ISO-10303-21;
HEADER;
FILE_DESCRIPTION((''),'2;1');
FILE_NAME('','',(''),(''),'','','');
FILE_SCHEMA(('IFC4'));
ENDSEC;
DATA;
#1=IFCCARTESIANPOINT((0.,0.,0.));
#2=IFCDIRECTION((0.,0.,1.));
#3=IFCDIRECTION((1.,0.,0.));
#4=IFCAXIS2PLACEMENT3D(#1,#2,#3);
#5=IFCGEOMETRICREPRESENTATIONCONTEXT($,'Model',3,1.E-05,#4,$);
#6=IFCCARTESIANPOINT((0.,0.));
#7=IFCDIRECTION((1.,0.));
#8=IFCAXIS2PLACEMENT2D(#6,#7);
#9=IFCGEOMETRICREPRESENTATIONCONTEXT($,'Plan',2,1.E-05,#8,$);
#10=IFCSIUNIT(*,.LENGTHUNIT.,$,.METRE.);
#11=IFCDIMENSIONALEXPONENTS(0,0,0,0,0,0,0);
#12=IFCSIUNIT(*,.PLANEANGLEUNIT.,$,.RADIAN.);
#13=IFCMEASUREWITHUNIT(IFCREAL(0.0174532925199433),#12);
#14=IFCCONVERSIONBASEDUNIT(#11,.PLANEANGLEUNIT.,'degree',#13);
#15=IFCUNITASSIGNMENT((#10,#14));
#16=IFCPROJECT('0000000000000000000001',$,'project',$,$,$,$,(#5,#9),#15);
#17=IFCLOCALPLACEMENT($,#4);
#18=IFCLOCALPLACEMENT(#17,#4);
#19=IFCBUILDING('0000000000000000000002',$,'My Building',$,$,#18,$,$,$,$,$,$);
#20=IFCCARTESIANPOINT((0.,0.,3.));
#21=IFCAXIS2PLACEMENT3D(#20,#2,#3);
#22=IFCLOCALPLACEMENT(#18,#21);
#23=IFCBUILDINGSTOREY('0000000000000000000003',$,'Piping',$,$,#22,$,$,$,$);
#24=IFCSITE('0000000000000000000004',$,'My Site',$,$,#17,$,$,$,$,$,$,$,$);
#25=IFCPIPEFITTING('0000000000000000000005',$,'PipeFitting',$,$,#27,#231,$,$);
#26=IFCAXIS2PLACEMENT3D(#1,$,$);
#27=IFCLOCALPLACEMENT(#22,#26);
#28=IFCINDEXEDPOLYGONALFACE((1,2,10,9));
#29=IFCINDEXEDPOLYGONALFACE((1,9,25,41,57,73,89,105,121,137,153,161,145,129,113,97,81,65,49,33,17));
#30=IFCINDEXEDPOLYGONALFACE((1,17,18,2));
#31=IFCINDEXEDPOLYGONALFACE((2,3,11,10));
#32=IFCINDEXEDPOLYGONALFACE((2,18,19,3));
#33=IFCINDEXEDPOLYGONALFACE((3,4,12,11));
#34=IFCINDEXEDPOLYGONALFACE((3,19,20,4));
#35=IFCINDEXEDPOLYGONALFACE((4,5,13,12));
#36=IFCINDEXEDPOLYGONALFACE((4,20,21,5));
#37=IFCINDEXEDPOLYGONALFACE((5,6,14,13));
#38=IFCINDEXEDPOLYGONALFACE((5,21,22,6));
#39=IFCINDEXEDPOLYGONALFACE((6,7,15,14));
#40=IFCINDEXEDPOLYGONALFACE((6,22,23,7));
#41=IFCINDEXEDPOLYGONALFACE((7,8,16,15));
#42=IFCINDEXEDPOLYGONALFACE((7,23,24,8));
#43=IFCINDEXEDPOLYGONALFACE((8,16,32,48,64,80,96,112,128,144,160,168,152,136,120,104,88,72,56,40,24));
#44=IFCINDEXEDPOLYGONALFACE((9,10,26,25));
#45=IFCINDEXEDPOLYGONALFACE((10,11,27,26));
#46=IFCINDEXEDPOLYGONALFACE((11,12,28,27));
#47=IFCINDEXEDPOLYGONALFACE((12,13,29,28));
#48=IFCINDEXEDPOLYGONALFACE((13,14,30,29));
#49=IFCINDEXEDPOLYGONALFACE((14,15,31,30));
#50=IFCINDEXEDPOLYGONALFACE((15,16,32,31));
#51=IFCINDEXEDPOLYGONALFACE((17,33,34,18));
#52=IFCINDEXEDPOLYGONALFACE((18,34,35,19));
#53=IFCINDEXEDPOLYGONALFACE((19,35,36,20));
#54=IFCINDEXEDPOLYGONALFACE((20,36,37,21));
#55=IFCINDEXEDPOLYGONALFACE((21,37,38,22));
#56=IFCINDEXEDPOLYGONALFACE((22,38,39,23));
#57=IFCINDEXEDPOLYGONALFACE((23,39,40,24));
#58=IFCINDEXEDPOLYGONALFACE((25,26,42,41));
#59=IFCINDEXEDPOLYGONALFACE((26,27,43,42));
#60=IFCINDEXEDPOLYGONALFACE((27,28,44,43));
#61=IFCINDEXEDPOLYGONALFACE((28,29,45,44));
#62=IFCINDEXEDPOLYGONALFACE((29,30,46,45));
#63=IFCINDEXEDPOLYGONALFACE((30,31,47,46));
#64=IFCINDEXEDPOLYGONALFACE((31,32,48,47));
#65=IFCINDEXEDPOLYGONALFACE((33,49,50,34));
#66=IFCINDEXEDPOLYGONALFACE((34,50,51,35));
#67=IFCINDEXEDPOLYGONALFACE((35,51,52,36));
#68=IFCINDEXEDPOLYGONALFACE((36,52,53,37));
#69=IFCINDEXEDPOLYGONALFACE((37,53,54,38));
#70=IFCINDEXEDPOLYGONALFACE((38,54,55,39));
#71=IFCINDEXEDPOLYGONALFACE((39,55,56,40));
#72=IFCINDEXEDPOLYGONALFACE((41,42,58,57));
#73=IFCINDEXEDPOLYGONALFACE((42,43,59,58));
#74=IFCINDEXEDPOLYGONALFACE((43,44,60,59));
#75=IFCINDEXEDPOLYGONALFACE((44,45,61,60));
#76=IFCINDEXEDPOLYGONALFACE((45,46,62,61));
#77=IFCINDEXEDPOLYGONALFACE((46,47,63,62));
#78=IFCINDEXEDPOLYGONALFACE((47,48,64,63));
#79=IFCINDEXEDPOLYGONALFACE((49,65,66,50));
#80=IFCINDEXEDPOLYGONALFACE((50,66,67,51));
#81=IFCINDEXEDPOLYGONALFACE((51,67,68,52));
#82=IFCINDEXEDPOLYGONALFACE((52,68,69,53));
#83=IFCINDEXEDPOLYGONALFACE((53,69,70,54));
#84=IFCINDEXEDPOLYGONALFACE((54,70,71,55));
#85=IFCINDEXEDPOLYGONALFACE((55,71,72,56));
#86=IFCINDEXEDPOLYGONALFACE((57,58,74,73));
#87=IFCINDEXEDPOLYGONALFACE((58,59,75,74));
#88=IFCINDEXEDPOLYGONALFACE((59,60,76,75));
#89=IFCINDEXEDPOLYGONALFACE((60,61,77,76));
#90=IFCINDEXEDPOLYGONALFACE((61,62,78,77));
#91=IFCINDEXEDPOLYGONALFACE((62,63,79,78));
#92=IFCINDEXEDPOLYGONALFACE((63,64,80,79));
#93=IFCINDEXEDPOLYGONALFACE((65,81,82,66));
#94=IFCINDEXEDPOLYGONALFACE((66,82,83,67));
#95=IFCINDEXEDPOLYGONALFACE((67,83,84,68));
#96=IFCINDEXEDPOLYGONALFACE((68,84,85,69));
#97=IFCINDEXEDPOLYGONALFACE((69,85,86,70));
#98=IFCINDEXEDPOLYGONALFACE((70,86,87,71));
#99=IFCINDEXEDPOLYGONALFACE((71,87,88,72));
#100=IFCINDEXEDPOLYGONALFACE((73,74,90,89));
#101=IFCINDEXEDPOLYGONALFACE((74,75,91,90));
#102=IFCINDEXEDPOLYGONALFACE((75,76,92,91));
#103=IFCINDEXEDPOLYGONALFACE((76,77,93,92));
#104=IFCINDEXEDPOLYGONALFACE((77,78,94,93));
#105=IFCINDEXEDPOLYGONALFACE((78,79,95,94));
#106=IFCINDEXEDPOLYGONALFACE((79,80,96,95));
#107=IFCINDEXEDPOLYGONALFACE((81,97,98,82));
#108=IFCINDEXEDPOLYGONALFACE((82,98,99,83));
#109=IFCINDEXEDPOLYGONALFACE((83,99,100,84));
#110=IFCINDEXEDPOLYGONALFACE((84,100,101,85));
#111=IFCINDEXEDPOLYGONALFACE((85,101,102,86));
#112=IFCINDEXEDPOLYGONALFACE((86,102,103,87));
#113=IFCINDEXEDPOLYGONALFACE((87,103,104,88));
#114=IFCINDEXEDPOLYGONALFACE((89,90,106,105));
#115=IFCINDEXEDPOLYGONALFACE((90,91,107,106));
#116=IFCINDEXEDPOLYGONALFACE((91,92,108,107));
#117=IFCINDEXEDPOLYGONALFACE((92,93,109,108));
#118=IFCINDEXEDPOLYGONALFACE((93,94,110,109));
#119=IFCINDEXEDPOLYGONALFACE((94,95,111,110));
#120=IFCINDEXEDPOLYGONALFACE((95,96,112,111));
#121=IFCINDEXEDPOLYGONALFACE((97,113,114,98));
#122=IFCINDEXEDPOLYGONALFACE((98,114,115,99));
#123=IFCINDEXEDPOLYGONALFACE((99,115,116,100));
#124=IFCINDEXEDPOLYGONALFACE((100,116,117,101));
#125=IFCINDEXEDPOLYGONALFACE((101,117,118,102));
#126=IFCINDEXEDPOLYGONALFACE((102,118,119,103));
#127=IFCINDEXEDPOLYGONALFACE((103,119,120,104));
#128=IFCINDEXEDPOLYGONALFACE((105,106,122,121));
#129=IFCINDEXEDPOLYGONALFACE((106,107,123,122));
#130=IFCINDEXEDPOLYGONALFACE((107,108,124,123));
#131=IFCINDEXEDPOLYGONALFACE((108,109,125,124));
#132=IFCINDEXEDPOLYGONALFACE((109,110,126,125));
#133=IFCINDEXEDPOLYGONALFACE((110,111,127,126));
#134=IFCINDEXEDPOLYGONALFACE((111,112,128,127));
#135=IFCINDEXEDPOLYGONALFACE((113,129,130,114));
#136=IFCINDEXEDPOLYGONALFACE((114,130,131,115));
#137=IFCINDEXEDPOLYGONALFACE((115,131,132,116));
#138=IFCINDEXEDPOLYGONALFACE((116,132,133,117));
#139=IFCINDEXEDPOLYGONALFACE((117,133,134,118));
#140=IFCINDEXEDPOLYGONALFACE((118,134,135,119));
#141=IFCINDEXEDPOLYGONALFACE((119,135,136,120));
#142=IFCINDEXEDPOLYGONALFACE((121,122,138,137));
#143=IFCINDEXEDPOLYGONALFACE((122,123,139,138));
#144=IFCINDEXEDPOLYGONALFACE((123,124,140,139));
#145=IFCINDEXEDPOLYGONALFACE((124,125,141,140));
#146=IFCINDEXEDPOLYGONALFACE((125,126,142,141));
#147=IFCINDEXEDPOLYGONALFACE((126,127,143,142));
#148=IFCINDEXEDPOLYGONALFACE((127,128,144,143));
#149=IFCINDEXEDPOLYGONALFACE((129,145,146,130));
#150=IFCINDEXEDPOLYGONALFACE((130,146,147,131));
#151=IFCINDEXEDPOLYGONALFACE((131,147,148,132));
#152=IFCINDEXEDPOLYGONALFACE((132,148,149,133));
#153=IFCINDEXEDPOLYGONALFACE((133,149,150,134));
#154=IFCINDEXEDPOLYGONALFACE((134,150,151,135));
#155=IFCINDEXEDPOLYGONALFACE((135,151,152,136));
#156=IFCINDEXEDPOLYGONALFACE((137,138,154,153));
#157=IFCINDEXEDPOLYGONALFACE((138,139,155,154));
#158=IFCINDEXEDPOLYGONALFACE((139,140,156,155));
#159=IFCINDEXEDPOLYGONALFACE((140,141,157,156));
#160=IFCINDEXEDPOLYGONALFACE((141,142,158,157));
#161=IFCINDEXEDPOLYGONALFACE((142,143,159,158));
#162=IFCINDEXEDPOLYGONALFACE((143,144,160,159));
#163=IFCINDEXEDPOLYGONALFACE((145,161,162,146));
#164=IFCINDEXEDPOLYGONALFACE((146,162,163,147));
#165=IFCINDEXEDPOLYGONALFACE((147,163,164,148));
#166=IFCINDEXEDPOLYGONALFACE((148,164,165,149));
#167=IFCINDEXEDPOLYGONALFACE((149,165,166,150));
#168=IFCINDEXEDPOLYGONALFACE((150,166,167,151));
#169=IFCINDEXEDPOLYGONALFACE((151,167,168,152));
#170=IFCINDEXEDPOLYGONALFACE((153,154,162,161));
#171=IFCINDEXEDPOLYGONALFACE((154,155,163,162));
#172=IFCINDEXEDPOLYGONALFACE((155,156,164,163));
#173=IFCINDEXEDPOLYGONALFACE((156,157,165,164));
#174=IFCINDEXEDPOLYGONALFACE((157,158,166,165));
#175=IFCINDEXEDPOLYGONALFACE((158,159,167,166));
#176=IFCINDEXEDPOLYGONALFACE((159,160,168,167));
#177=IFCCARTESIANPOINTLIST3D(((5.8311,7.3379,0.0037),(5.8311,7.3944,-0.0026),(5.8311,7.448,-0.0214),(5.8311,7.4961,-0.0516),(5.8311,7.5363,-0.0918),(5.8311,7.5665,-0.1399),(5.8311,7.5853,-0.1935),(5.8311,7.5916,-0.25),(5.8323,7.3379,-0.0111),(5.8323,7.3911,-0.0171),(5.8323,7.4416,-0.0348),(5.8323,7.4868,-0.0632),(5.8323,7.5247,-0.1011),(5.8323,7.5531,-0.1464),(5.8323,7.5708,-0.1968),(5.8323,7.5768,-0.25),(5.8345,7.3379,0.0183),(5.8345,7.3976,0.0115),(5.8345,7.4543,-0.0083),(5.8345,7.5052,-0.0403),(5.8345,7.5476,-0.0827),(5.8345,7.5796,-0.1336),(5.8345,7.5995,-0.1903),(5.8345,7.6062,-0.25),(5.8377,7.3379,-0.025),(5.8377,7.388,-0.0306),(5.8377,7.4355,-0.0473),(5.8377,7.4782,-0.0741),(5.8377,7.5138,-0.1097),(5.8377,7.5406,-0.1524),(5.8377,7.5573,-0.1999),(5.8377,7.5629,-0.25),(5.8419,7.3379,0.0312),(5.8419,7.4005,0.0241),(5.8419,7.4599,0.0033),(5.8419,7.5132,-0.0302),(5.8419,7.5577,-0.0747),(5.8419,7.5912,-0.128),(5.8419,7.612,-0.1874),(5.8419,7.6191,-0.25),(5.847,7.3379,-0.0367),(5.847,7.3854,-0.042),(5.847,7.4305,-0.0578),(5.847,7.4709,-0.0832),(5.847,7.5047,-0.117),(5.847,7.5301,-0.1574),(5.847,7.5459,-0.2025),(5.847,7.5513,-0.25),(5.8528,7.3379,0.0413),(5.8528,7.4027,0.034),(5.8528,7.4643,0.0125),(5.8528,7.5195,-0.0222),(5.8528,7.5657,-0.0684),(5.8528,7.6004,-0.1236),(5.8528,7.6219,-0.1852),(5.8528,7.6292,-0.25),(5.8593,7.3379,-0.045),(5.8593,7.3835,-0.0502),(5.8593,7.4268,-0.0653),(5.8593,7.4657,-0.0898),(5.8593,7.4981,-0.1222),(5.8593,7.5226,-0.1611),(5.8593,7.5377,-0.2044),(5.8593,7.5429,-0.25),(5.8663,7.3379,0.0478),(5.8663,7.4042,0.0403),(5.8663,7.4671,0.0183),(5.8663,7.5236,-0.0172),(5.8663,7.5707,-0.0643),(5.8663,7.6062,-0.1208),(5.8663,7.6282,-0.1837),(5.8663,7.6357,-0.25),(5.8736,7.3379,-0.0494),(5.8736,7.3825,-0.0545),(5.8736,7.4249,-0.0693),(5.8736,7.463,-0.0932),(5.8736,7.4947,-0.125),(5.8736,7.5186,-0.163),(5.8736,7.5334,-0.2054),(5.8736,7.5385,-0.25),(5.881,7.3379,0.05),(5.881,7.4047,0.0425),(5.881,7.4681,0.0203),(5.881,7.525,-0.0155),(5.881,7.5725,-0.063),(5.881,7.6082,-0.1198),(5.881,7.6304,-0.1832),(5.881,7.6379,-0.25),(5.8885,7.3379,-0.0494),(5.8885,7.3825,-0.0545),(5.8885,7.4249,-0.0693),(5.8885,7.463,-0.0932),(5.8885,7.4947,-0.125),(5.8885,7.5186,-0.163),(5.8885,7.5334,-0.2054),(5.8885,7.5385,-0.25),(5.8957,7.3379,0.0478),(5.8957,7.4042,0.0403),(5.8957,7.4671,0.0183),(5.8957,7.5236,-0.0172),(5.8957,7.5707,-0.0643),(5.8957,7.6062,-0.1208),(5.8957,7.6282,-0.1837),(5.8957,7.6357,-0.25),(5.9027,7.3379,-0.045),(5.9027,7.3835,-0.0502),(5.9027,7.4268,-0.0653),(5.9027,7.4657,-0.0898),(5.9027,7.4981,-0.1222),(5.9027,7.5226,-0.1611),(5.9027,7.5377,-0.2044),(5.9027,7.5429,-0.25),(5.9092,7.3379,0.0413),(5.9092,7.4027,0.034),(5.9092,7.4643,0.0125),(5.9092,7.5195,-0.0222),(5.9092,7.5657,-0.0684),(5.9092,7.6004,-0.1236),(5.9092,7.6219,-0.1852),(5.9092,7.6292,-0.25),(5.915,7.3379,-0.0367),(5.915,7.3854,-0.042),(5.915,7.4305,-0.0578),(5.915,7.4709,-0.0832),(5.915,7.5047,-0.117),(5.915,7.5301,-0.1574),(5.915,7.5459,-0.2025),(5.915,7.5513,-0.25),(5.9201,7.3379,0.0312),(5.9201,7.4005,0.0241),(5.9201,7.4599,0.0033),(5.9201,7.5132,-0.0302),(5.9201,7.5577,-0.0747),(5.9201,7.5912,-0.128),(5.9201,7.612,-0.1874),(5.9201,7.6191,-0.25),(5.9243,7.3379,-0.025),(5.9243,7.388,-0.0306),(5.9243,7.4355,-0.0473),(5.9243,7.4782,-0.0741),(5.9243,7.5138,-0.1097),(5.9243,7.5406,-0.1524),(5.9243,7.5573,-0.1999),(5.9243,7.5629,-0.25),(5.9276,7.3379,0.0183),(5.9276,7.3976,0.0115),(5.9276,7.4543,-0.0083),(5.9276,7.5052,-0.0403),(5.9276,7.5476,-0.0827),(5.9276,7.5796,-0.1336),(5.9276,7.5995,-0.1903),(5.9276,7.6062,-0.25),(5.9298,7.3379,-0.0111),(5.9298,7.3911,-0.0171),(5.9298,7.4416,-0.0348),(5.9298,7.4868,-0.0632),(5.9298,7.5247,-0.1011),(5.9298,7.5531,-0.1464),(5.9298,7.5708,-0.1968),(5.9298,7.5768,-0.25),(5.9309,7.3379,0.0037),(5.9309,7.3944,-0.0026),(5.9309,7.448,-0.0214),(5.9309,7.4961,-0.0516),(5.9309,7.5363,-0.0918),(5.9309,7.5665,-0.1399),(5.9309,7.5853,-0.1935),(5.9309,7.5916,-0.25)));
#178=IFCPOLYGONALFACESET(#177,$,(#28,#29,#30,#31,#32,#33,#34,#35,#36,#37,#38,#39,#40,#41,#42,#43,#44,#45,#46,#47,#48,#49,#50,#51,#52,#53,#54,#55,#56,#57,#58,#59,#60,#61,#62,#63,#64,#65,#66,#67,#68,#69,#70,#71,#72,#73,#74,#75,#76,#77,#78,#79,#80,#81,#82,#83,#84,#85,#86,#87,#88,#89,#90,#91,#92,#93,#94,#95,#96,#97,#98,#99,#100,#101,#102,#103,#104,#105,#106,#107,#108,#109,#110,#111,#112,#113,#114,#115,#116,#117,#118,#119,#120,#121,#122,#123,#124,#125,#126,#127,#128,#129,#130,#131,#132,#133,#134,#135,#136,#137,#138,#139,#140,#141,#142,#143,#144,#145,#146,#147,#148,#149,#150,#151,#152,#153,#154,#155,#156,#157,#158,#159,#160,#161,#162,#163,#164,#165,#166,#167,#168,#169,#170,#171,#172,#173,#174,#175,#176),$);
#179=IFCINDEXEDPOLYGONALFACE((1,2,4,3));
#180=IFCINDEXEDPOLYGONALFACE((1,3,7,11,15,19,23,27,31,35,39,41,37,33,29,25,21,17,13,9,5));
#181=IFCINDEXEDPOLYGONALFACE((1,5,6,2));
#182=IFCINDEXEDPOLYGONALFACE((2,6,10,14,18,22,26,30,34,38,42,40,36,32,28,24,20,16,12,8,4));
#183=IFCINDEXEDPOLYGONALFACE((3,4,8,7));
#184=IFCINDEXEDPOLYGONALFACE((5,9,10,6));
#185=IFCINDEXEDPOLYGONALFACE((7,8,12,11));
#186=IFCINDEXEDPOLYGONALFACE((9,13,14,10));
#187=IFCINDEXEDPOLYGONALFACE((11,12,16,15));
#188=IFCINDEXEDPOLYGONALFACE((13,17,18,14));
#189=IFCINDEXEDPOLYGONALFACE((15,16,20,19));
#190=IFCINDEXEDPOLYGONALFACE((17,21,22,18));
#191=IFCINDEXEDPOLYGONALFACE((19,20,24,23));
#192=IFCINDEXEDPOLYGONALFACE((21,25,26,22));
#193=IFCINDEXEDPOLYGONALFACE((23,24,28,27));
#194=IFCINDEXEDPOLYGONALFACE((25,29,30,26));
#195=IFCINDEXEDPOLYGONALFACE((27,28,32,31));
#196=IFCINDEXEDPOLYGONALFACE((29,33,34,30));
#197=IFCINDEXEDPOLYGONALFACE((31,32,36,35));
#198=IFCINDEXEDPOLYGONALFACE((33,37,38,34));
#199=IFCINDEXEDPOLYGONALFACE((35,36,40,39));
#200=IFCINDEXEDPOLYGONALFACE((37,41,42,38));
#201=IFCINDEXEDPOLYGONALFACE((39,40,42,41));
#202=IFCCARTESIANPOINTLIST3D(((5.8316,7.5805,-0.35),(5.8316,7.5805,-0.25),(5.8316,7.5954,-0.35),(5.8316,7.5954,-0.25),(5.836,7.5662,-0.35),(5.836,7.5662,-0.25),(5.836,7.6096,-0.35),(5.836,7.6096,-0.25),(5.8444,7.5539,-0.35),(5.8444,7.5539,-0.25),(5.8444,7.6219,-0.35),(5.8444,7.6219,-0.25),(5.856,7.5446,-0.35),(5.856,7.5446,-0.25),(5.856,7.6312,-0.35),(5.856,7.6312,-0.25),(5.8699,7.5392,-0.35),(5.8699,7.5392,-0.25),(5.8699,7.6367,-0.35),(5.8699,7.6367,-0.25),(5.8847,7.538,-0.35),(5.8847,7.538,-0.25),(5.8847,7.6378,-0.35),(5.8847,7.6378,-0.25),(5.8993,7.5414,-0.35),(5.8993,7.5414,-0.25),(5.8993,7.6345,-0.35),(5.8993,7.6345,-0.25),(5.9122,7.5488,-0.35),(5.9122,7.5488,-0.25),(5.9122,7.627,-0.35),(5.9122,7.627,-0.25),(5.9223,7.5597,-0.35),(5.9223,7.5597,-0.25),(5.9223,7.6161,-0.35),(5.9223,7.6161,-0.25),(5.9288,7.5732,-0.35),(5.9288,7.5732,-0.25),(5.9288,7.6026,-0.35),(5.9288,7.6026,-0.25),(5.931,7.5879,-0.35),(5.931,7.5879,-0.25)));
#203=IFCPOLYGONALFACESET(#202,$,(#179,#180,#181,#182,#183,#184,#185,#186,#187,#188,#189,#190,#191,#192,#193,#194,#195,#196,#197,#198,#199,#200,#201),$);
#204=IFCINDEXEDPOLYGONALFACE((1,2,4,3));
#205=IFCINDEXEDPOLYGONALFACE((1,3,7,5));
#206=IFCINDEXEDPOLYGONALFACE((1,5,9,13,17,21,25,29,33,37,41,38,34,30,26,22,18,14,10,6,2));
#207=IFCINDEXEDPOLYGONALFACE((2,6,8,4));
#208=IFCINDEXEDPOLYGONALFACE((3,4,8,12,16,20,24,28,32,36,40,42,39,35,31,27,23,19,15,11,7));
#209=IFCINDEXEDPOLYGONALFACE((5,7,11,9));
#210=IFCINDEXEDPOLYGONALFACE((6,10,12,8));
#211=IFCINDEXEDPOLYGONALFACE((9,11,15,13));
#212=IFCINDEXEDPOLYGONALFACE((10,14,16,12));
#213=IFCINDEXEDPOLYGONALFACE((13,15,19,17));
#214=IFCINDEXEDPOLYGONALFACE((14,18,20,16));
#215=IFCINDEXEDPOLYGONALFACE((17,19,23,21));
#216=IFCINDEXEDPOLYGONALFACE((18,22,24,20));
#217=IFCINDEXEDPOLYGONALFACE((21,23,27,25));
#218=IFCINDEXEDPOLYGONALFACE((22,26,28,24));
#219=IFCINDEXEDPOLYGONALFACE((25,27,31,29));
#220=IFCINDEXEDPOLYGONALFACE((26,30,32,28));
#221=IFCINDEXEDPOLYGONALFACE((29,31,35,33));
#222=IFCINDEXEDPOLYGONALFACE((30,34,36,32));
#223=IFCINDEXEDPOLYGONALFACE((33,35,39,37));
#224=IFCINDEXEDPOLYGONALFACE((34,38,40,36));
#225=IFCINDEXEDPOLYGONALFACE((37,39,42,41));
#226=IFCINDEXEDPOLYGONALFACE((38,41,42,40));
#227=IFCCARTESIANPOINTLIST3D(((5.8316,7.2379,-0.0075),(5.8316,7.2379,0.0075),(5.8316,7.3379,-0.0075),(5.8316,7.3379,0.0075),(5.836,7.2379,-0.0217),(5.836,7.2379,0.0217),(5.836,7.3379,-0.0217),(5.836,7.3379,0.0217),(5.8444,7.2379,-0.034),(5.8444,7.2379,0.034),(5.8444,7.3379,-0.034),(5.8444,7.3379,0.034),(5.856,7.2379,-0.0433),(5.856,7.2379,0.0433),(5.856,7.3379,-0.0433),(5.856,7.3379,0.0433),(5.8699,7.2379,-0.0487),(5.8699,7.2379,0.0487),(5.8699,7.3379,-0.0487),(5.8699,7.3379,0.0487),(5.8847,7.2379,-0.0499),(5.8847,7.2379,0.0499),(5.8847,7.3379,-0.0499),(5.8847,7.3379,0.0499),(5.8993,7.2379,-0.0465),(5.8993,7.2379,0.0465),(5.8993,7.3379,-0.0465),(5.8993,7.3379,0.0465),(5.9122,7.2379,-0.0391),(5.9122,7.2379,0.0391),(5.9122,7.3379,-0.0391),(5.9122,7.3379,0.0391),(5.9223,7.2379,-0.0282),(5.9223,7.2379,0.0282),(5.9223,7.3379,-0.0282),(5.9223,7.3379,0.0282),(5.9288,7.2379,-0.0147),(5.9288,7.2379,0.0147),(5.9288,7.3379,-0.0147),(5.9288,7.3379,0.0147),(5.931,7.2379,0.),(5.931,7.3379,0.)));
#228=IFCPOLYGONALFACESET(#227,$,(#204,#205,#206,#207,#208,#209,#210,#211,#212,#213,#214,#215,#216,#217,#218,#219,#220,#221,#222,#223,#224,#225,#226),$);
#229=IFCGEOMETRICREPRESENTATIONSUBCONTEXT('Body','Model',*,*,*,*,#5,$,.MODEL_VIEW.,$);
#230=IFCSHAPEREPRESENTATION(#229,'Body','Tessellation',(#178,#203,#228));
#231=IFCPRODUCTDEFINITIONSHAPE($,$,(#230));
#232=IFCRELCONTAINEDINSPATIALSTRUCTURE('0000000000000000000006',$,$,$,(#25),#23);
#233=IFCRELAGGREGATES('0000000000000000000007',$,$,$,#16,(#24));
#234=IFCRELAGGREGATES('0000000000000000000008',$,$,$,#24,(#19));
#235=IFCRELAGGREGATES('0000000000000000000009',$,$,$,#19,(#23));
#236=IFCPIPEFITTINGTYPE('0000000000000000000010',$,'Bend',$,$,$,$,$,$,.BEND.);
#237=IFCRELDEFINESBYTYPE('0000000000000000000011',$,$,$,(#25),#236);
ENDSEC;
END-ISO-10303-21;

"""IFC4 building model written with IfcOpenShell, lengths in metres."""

from ifc_helpers import new_model, entity, si_unit, converted_unit, frame, origin_with_axes, origin_2d_with_axis, place, context, subcontext, project, spatial, line, indexed_curve, circle, outline, extrude, source, transform, mapped, type_object, type_shapes, element, save


model = new_model("IFC4")

# Units and contexts
model_context = context("Model", 3, precision=1e-05, world=origin_with_axes())
plan_context = context("Plan", 2, precision=1e-05, world=origin_2d_with_axis())
body_context = subcontext(model_context, "Body", "Model", "MODEL_VIEW")
ifc_project = project(units=[si_unit("LENGTHUNIT", "METRE"), converted_unit("PLANEANGLEUNIT", "degree", entity("IfcReal", 0.0174532925199433), si_unit("PLANEANGLEUNIT", "RADIAN"), dimensions=[0, 0, 0, 0, 0, 0, 0])], contexts=[model_context, plan_context])

# Site, building, storey
site_placement = place(None, origin_with_axes())
site = spatial("IfcSite", under=ifc_project, at=site_placement, Name="My Site")
building_placement = place(site_placement, origin_with_axes())
building = spatial("IfcBuilding", under=site, at=building_placement, Name="My Building")
storey_placement = place(building_placement, frame((0.0, 0.0, 3.0), z_axis=(0.0, 0.0, 1.0), x_axis=(1.0, 0.0, 0.0)))
storey = spatial("IfcBuildingStorey", under=building, at=storey_placement, Name="Piping")

# Pipe fitting, opening
pipe_fitting_type = type_object("IfcPipeFittingType", Name="Bend", PredefinedType="BEND")
shared_shape = source(origin_with_axes(), body_context, "Body", "SolidModel", [
    entity("IfcSweptDiskSolid", entity("IfcIndexedPolyCurve", entity("IfcCartesianPointList3D", [[0.0, 0.0, -0.1], [0.0, 0.0732, -0.2768], [0.0, 0.25, -0.35]]), [entity("IfcArcIndex", [1, 2, 3])]), 0.05),
    extrude(circle(Radius=0.05), origin_with_axes(), (0.0, 0.0, -1.0), 0.1),
    extrude(circle(Radius=0.05), frame((0.0, 0.25, -0.35), z_axis=(0.0, 1.0, 0.0), x_axis=(1.0, 0.0, 0.0)), (0.0, 0.0, 1.0), 0.1),
])
type_shapes(pipe_fitting_type, [shared_shape])
pipe_fitting_1_placement = place(storey_placement, frame((5.881, 7.5879, -0.35), z_axis=(0.0, 0.0, -1.0), x_axis=(1.0, 0.0, 0.0)))
pipe_fitting_1 = element("IfcPipeFitting", 1, at=pipe_fitting_1_placement, inside=storey, type_object=pipe_fitting_type, Name="PipeFitting", context=body_context, shape_type="MappedRepresentation", body=[
    mapped(shared_shape, transform((0.0, 0.0, 0.0), x_axis=(1.0, 0.0, 0.0), y_axis=(0.0, 1.0, 0.0), z_axis=(0.0, 0.0, 1.0), scale=1.0)),
])
opening_1_placement = place(pipe_fitting_1_placement, frame((1.9673, -1.5235, 2.65), z_axis=(0.0, 0.0, -1.0), x_axis=(-1.0, 0.0, 0.0)))
element("IfcOpeningElement", 2, at=opening_1_placement, cuts=pipe_fitting_1, PredefinedType="OPENING", context=body_context, shape_type="SweptSolid", body=[
    extrude(outline(indexed_curve([(0.0, 0.0), (0.5, 0.0), (0.5, 0.5), (0.0, 0.5)], segments=[line(1, 2, 3, 4, 1)])), origin_with_axes(), (0.0, 0.0, 1.0), 0.5),
])

save(model, "model.ifc")
